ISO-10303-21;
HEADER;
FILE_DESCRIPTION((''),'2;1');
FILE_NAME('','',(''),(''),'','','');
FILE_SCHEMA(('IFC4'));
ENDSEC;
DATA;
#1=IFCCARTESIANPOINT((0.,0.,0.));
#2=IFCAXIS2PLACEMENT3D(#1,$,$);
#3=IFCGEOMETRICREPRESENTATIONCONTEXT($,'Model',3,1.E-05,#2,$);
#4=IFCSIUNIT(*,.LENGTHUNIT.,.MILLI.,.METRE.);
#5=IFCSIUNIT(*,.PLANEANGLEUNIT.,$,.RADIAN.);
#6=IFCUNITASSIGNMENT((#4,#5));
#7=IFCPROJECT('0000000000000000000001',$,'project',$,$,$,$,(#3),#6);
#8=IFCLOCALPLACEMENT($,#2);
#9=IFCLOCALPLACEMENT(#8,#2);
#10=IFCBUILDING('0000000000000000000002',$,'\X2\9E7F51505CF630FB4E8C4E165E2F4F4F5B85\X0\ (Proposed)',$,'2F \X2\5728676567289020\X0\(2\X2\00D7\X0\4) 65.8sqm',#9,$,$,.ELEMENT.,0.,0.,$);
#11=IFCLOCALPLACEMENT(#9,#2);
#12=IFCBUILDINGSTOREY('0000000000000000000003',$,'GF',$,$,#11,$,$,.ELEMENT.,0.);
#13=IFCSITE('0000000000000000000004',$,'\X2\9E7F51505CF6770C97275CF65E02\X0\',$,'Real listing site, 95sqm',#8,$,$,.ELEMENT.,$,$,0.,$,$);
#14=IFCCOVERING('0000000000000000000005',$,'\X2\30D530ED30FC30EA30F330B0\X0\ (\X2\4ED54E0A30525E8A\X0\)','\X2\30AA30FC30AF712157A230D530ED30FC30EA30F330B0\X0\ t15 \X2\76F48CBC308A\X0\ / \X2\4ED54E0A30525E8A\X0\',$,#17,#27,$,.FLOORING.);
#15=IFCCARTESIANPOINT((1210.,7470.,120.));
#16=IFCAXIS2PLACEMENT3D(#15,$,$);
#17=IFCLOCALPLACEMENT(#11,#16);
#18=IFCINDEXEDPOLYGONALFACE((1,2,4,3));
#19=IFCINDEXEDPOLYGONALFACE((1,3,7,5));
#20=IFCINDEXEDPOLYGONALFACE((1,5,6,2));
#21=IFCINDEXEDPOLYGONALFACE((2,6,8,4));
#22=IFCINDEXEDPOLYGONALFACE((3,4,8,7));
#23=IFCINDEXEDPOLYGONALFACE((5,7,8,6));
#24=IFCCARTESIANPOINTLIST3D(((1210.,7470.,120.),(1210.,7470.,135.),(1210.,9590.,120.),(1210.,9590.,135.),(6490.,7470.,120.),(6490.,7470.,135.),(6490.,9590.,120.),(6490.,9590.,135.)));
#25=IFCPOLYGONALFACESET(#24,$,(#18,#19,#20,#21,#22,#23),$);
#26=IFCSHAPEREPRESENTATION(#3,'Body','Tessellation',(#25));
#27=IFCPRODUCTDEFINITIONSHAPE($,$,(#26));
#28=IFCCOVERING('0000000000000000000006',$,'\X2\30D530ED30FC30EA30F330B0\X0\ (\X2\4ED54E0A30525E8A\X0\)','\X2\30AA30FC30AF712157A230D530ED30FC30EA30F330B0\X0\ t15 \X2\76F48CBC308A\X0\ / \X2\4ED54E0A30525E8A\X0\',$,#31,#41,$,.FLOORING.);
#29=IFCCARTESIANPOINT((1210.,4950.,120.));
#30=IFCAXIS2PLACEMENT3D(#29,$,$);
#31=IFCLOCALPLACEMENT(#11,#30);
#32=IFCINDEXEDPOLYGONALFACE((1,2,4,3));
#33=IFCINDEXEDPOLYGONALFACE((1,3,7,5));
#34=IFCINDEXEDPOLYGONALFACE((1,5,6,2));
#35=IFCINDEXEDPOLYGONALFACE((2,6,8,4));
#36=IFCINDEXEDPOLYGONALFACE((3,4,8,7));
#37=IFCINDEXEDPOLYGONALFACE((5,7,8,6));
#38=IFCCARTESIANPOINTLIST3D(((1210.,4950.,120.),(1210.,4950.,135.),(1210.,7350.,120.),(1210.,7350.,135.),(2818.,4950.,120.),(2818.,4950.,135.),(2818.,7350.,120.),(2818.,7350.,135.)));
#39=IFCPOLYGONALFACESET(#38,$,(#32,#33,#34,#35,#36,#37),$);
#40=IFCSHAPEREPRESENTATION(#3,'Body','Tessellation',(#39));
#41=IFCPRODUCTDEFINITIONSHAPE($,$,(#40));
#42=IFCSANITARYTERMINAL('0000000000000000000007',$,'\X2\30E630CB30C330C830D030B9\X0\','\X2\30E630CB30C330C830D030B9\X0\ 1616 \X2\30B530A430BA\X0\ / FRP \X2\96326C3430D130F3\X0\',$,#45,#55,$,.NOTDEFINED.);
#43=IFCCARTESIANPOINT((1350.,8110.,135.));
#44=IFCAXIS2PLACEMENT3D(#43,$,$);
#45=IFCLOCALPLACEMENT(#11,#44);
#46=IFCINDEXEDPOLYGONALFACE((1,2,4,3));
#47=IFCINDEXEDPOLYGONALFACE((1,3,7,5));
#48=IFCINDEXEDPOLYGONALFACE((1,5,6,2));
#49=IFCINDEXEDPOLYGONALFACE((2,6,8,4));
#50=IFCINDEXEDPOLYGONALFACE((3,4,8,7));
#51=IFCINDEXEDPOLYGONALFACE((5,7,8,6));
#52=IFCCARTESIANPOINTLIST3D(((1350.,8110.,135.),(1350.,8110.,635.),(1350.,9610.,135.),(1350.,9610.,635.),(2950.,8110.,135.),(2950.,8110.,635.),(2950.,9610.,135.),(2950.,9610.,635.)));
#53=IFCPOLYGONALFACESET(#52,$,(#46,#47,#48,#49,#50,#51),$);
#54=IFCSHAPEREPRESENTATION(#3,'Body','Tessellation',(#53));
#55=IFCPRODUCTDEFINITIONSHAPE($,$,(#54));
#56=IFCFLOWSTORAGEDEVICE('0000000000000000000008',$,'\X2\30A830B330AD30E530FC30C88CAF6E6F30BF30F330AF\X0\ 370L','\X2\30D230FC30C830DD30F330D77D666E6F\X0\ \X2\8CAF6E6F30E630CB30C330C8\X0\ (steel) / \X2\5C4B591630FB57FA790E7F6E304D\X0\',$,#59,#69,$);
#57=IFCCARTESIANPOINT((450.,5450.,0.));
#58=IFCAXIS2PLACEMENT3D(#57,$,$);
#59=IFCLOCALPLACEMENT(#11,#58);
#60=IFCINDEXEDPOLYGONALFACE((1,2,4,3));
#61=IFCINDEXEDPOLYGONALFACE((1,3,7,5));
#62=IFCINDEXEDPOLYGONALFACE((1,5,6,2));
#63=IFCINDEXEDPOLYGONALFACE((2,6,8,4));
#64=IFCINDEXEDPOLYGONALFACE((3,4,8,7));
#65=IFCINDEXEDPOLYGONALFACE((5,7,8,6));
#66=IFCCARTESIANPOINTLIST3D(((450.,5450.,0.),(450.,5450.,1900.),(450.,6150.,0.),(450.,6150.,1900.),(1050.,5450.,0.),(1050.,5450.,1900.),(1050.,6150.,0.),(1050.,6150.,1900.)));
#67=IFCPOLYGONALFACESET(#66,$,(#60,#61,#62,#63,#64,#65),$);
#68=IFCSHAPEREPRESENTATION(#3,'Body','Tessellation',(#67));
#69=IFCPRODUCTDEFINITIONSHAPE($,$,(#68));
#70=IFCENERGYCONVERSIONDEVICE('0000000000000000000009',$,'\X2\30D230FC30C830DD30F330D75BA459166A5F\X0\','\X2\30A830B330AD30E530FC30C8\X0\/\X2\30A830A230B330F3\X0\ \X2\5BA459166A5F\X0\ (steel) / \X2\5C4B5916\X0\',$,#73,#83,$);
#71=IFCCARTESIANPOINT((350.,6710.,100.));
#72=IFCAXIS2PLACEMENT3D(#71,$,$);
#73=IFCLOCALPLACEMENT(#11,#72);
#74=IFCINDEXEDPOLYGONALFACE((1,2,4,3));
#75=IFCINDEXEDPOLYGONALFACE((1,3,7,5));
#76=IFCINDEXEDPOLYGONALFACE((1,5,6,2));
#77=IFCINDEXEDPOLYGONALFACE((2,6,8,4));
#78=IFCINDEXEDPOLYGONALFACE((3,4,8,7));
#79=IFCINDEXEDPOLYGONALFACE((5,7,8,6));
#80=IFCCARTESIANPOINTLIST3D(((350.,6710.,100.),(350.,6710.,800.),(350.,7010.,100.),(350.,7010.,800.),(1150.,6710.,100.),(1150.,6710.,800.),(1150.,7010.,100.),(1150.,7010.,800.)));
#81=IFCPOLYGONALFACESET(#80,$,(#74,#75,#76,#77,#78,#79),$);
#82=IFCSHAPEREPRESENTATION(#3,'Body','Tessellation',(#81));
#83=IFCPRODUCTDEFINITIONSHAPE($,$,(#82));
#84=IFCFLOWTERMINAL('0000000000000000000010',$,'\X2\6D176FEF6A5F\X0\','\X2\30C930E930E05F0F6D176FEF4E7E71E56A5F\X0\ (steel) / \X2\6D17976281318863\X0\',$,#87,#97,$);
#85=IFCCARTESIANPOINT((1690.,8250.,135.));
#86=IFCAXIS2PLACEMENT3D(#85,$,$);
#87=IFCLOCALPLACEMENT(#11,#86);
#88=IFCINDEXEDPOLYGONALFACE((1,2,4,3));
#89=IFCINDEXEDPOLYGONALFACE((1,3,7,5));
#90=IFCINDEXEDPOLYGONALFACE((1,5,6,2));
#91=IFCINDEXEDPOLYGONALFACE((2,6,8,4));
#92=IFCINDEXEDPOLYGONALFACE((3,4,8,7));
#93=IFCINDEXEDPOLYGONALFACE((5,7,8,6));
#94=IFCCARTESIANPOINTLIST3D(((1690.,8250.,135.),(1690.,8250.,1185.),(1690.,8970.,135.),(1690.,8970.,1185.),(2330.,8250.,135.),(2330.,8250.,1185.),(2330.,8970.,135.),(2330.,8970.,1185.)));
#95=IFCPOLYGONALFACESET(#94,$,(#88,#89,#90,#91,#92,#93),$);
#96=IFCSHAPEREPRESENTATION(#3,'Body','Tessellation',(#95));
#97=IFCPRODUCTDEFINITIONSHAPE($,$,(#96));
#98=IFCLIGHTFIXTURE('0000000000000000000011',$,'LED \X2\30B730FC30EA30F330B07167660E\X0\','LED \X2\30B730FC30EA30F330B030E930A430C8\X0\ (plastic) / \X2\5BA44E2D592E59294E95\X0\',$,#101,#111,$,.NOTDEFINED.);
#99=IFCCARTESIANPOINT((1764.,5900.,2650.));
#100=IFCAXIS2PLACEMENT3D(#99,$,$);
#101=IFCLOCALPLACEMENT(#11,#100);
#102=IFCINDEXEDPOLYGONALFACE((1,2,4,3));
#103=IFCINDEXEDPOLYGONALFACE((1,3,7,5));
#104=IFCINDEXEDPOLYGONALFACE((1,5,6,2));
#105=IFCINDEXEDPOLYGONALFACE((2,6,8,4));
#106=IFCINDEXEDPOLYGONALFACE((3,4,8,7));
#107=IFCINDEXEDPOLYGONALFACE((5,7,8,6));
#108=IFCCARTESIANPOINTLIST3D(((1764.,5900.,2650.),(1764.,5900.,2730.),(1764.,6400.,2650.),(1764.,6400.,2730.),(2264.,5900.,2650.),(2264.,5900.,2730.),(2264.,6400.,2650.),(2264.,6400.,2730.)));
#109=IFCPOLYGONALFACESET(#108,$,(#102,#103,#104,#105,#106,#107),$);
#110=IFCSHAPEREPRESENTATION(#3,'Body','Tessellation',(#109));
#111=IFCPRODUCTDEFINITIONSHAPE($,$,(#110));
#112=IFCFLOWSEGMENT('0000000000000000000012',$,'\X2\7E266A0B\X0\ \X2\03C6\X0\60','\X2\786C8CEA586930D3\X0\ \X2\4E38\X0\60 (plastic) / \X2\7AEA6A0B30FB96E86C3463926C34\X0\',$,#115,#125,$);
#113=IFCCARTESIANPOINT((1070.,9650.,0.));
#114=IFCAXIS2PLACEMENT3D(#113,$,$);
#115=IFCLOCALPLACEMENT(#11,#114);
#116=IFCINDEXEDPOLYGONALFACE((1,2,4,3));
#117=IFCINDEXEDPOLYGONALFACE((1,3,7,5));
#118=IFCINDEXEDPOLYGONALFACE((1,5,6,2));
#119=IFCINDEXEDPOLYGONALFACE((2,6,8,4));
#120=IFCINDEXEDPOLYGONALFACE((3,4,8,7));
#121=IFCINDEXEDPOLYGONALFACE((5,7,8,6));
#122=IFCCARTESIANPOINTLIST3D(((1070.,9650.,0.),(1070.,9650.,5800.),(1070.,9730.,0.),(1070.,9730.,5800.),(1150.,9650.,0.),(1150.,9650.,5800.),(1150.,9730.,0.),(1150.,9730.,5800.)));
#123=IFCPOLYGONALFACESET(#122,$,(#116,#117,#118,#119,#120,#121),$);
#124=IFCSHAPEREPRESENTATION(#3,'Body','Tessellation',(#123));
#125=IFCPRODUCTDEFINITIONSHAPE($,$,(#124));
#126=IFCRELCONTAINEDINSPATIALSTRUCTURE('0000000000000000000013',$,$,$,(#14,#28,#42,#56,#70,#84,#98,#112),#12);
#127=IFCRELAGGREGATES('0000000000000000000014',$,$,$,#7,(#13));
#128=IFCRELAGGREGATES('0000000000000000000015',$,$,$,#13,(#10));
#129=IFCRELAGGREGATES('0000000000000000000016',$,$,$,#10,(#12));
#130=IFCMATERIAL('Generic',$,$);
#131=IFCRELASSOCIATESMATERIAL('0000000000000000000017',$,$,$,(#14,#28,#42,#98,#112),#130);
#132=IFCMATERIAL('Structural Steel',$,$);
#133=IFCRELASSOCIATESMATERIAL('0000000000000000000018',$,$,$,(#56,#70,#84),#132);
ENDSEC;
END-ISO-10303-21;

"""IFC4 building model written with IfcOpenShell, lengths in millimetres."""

from ifc_helpers import new_model, si_unit, frame, frame_2d, origin, place, context, project, spatial, rectangle, extrude, material, element, save


model = new_model("IFC4")

# Units and contexts
model_context = context("Model", 3, precision=1e-05, world=origin())
ifc_project = project(units=[si_unit("LENGTHUNIT", "METRE", prefix="MILLI"), si_unit("PLANEANGLEUNIT", "RADIAN")], contexts=[model_context])

# Site, building, storey
site_placement = place(None, origin())
site = spatial("IfcSite", under=ifc_project, at=site_placement, Name="鹿児島県霧島市", ObjectType="Real listing site, 95sqm", CompositionType="ELEMENT", RefElevation=0.0)
building_placement = place(site_placement, origin())
building = spatial("IfcBuilding", under=site, at=building_placement, Name="鹿児島・二世帯住宅 (Proposed)", ObjectType="2F 在来木造(2×4) 65.8sqm", CompositionType="ELEMENT", ElevationOfRefHeight=0.0, ElevationOfTerrain=0.0)
storey_placement = place(building_placement, origin())
storey = spatial("IfcBuildingStorey", under=building, at=storey_placement, Name="GF", CompositionType="ELEMENT", Elevation=0.0)

# Coverings
ifc_material_1 = material(Name="Generic")
covering_1_placement = place(storey_placement, frame((1210.0, 7470.0, 120.0)))
element("IfcCovering", 1, at=covering_1_placement, inside=storey, material=ifc_material_1, Name="フローリング (仕上げ床)", Description="オーク無垢フローリング t15 直貼り / 仕上げ床", PredefinedType="FLOORING", context=model_context, shape_type="SweptSolid", body=[
    extrude(rectangle(XDim=5280.0, YDim=2120.0, at=frame_2d((2640.0, 1060.0))), frame((1210.0, 7470.0, 120.0)), (0.0, 0.0, 1.0), 15.0),
])
covering_2_placement = place(storey_placement, frame((1210.0, 4950.0, 120.0)))
element("IfcCovering", 2, at=covering_2_placement, inside=storey, material=ifc_material_1, Name="フローリング (仕上げ床)", Description="オーク無垢フローリング t15 直貼り / 仕上げ床", PredefinedType="FLOORING", context=model_context, shape_type="SweptSolid", body=[
    extrude(rectangle(XDim=1608.0, YDim=2400.0, at=frame_2d((804.0, 1200.0))), frame((1210.0, 4950.0, 120.0)), (0.0, 0.0, 1.0), 15.0),
])

# Sanitary terminal
sanitary_terminal_placement = place(storey_placement, frame((1350.0, 8110.0, 135.0)))
element("IfcSanitaryTerminal", 3, at=sanitary_terminal_placement, inside=storey, material=ifc_material_1, Name="ユニットバス", Description="ユニットバス 1616 サイズ / FRP 防水パン", PredefinedType="NOTDEFINED", context=model_context, shape_type="SweptSolid", body=[
    extrude(rectangle(XDim=1600.0, YDim=1500.0, at=frame_2d((800.0, 750.0))), frame((1350.0, 8110.0, 135.0)), (0.0, 0.0, 1.0), 500.0),
])

# Flow storage device
ifc_material_2 = material(Name="Structural Steel")
flow_storage_device_placement = place(storey_placement, frame((450.0, 5450.0, 0.0)))
element("IfcFlowStorageDevice", 4, at=flow_storage_device_placement, inside=storey, material=ifc_material_2, Name="エコキュート貯湯タンク 370L", Description="ヒートポンプ給湯 貯湯ユニット (steel) / 屋外・基礎置き", context=model_context, shape_type="SweptSolid", body=[
    extrude(rectangle(XDim=600.0, YDim=700.0, at=frame_2d((300.0, 350.0))), frame((450.0, 5450.0, 0.0)), (0.0, 0.0, 1.0), 1900.0),
])

# Energy conversion device
energy_conversion_device_placement = place(storey_placement, frame((350.0, 6710.0, 100.0)))
element("IfcEnergyConversionDevice", 5, at=energy_conversion_device_placement, inside=storey, material=ifc_material_2, Name="ヒートポンプ室外機", Description="エコキュート/エアコン 室外機 (steel) / 屋外", context=model_context, shape_type="SweptSolid", body=[
    extrude(rectangle(XDim=800.0, YDim=300.0, at=frame_2d((400.0, 150.0))), frame((350.0, 6710.0, 100.0)), (0.0, 0.0, 1.0), 700.0),
])

# Flow terminal
flow_terminal_placement = place(storey_placement, frame((1690.0, 8250.0, 135.0)))
element("IfcFlowTerminal", 6, at=flow_terminal_placement, inside=storey, material=ifc_material_2, Name="洗濯機", Description="ドラム式洗濯乾燥機 (steel) / 洗面脱衣", context=model_context, shape_type="SweptSolid", body=[
    extrude(rectangle(XDim=640.0, YDim=720.0, at=frame_2d((320.0, 360.0))), frame((1690.0, 8250.0, 135.0)), (0.0, 0.0, 1.0), 1050.0),
])

# Light fixture
light_fixture_placement = place(storey_placement, frame((1764.0, 5900.0, 2650.0)))
element("IfcLightFixture", 7, at=light_fixture_placement, inside=storey, material=ifc_material_1, Name="LED シーリング照明", Description="LED シーリングライト (plastic) / 室中央天井", PredefinedType="NOTDEFINED", context=model_context, shape_type="SweptSolid", body=[
    extrude(rectangle(XDim=500.0, YDim=500.0, at=frame_2d((250.0, 250.0))), frame((1764.0, 5900.0, 2650.0)), (0.0, 0.0, 1.0), 80.0),
])

# Flow segment
flow_segment_placement = place(storey_placement, frame((1070.0, 9650.0, 0.0)))
element("IfcFlowSegment", 8, at=flow_segment_placement, inside=storey, material=ifc_material_1, Name="縦樋 φ60", Description="硬質塩ビ 丸60 (plastic) / 竪樋・雨水排水", context=model_context, shape_type="SweptSolid", body=[
    extrude(rectangle(XDim=80.0, YDim=80.0, at=frame_2d((40.0, 40.0))), frame((1070.0, 9650.0, 0.0)), (0.0, 0.0, 1.0), 5800.0),
])

save(model, "model.ifc")
